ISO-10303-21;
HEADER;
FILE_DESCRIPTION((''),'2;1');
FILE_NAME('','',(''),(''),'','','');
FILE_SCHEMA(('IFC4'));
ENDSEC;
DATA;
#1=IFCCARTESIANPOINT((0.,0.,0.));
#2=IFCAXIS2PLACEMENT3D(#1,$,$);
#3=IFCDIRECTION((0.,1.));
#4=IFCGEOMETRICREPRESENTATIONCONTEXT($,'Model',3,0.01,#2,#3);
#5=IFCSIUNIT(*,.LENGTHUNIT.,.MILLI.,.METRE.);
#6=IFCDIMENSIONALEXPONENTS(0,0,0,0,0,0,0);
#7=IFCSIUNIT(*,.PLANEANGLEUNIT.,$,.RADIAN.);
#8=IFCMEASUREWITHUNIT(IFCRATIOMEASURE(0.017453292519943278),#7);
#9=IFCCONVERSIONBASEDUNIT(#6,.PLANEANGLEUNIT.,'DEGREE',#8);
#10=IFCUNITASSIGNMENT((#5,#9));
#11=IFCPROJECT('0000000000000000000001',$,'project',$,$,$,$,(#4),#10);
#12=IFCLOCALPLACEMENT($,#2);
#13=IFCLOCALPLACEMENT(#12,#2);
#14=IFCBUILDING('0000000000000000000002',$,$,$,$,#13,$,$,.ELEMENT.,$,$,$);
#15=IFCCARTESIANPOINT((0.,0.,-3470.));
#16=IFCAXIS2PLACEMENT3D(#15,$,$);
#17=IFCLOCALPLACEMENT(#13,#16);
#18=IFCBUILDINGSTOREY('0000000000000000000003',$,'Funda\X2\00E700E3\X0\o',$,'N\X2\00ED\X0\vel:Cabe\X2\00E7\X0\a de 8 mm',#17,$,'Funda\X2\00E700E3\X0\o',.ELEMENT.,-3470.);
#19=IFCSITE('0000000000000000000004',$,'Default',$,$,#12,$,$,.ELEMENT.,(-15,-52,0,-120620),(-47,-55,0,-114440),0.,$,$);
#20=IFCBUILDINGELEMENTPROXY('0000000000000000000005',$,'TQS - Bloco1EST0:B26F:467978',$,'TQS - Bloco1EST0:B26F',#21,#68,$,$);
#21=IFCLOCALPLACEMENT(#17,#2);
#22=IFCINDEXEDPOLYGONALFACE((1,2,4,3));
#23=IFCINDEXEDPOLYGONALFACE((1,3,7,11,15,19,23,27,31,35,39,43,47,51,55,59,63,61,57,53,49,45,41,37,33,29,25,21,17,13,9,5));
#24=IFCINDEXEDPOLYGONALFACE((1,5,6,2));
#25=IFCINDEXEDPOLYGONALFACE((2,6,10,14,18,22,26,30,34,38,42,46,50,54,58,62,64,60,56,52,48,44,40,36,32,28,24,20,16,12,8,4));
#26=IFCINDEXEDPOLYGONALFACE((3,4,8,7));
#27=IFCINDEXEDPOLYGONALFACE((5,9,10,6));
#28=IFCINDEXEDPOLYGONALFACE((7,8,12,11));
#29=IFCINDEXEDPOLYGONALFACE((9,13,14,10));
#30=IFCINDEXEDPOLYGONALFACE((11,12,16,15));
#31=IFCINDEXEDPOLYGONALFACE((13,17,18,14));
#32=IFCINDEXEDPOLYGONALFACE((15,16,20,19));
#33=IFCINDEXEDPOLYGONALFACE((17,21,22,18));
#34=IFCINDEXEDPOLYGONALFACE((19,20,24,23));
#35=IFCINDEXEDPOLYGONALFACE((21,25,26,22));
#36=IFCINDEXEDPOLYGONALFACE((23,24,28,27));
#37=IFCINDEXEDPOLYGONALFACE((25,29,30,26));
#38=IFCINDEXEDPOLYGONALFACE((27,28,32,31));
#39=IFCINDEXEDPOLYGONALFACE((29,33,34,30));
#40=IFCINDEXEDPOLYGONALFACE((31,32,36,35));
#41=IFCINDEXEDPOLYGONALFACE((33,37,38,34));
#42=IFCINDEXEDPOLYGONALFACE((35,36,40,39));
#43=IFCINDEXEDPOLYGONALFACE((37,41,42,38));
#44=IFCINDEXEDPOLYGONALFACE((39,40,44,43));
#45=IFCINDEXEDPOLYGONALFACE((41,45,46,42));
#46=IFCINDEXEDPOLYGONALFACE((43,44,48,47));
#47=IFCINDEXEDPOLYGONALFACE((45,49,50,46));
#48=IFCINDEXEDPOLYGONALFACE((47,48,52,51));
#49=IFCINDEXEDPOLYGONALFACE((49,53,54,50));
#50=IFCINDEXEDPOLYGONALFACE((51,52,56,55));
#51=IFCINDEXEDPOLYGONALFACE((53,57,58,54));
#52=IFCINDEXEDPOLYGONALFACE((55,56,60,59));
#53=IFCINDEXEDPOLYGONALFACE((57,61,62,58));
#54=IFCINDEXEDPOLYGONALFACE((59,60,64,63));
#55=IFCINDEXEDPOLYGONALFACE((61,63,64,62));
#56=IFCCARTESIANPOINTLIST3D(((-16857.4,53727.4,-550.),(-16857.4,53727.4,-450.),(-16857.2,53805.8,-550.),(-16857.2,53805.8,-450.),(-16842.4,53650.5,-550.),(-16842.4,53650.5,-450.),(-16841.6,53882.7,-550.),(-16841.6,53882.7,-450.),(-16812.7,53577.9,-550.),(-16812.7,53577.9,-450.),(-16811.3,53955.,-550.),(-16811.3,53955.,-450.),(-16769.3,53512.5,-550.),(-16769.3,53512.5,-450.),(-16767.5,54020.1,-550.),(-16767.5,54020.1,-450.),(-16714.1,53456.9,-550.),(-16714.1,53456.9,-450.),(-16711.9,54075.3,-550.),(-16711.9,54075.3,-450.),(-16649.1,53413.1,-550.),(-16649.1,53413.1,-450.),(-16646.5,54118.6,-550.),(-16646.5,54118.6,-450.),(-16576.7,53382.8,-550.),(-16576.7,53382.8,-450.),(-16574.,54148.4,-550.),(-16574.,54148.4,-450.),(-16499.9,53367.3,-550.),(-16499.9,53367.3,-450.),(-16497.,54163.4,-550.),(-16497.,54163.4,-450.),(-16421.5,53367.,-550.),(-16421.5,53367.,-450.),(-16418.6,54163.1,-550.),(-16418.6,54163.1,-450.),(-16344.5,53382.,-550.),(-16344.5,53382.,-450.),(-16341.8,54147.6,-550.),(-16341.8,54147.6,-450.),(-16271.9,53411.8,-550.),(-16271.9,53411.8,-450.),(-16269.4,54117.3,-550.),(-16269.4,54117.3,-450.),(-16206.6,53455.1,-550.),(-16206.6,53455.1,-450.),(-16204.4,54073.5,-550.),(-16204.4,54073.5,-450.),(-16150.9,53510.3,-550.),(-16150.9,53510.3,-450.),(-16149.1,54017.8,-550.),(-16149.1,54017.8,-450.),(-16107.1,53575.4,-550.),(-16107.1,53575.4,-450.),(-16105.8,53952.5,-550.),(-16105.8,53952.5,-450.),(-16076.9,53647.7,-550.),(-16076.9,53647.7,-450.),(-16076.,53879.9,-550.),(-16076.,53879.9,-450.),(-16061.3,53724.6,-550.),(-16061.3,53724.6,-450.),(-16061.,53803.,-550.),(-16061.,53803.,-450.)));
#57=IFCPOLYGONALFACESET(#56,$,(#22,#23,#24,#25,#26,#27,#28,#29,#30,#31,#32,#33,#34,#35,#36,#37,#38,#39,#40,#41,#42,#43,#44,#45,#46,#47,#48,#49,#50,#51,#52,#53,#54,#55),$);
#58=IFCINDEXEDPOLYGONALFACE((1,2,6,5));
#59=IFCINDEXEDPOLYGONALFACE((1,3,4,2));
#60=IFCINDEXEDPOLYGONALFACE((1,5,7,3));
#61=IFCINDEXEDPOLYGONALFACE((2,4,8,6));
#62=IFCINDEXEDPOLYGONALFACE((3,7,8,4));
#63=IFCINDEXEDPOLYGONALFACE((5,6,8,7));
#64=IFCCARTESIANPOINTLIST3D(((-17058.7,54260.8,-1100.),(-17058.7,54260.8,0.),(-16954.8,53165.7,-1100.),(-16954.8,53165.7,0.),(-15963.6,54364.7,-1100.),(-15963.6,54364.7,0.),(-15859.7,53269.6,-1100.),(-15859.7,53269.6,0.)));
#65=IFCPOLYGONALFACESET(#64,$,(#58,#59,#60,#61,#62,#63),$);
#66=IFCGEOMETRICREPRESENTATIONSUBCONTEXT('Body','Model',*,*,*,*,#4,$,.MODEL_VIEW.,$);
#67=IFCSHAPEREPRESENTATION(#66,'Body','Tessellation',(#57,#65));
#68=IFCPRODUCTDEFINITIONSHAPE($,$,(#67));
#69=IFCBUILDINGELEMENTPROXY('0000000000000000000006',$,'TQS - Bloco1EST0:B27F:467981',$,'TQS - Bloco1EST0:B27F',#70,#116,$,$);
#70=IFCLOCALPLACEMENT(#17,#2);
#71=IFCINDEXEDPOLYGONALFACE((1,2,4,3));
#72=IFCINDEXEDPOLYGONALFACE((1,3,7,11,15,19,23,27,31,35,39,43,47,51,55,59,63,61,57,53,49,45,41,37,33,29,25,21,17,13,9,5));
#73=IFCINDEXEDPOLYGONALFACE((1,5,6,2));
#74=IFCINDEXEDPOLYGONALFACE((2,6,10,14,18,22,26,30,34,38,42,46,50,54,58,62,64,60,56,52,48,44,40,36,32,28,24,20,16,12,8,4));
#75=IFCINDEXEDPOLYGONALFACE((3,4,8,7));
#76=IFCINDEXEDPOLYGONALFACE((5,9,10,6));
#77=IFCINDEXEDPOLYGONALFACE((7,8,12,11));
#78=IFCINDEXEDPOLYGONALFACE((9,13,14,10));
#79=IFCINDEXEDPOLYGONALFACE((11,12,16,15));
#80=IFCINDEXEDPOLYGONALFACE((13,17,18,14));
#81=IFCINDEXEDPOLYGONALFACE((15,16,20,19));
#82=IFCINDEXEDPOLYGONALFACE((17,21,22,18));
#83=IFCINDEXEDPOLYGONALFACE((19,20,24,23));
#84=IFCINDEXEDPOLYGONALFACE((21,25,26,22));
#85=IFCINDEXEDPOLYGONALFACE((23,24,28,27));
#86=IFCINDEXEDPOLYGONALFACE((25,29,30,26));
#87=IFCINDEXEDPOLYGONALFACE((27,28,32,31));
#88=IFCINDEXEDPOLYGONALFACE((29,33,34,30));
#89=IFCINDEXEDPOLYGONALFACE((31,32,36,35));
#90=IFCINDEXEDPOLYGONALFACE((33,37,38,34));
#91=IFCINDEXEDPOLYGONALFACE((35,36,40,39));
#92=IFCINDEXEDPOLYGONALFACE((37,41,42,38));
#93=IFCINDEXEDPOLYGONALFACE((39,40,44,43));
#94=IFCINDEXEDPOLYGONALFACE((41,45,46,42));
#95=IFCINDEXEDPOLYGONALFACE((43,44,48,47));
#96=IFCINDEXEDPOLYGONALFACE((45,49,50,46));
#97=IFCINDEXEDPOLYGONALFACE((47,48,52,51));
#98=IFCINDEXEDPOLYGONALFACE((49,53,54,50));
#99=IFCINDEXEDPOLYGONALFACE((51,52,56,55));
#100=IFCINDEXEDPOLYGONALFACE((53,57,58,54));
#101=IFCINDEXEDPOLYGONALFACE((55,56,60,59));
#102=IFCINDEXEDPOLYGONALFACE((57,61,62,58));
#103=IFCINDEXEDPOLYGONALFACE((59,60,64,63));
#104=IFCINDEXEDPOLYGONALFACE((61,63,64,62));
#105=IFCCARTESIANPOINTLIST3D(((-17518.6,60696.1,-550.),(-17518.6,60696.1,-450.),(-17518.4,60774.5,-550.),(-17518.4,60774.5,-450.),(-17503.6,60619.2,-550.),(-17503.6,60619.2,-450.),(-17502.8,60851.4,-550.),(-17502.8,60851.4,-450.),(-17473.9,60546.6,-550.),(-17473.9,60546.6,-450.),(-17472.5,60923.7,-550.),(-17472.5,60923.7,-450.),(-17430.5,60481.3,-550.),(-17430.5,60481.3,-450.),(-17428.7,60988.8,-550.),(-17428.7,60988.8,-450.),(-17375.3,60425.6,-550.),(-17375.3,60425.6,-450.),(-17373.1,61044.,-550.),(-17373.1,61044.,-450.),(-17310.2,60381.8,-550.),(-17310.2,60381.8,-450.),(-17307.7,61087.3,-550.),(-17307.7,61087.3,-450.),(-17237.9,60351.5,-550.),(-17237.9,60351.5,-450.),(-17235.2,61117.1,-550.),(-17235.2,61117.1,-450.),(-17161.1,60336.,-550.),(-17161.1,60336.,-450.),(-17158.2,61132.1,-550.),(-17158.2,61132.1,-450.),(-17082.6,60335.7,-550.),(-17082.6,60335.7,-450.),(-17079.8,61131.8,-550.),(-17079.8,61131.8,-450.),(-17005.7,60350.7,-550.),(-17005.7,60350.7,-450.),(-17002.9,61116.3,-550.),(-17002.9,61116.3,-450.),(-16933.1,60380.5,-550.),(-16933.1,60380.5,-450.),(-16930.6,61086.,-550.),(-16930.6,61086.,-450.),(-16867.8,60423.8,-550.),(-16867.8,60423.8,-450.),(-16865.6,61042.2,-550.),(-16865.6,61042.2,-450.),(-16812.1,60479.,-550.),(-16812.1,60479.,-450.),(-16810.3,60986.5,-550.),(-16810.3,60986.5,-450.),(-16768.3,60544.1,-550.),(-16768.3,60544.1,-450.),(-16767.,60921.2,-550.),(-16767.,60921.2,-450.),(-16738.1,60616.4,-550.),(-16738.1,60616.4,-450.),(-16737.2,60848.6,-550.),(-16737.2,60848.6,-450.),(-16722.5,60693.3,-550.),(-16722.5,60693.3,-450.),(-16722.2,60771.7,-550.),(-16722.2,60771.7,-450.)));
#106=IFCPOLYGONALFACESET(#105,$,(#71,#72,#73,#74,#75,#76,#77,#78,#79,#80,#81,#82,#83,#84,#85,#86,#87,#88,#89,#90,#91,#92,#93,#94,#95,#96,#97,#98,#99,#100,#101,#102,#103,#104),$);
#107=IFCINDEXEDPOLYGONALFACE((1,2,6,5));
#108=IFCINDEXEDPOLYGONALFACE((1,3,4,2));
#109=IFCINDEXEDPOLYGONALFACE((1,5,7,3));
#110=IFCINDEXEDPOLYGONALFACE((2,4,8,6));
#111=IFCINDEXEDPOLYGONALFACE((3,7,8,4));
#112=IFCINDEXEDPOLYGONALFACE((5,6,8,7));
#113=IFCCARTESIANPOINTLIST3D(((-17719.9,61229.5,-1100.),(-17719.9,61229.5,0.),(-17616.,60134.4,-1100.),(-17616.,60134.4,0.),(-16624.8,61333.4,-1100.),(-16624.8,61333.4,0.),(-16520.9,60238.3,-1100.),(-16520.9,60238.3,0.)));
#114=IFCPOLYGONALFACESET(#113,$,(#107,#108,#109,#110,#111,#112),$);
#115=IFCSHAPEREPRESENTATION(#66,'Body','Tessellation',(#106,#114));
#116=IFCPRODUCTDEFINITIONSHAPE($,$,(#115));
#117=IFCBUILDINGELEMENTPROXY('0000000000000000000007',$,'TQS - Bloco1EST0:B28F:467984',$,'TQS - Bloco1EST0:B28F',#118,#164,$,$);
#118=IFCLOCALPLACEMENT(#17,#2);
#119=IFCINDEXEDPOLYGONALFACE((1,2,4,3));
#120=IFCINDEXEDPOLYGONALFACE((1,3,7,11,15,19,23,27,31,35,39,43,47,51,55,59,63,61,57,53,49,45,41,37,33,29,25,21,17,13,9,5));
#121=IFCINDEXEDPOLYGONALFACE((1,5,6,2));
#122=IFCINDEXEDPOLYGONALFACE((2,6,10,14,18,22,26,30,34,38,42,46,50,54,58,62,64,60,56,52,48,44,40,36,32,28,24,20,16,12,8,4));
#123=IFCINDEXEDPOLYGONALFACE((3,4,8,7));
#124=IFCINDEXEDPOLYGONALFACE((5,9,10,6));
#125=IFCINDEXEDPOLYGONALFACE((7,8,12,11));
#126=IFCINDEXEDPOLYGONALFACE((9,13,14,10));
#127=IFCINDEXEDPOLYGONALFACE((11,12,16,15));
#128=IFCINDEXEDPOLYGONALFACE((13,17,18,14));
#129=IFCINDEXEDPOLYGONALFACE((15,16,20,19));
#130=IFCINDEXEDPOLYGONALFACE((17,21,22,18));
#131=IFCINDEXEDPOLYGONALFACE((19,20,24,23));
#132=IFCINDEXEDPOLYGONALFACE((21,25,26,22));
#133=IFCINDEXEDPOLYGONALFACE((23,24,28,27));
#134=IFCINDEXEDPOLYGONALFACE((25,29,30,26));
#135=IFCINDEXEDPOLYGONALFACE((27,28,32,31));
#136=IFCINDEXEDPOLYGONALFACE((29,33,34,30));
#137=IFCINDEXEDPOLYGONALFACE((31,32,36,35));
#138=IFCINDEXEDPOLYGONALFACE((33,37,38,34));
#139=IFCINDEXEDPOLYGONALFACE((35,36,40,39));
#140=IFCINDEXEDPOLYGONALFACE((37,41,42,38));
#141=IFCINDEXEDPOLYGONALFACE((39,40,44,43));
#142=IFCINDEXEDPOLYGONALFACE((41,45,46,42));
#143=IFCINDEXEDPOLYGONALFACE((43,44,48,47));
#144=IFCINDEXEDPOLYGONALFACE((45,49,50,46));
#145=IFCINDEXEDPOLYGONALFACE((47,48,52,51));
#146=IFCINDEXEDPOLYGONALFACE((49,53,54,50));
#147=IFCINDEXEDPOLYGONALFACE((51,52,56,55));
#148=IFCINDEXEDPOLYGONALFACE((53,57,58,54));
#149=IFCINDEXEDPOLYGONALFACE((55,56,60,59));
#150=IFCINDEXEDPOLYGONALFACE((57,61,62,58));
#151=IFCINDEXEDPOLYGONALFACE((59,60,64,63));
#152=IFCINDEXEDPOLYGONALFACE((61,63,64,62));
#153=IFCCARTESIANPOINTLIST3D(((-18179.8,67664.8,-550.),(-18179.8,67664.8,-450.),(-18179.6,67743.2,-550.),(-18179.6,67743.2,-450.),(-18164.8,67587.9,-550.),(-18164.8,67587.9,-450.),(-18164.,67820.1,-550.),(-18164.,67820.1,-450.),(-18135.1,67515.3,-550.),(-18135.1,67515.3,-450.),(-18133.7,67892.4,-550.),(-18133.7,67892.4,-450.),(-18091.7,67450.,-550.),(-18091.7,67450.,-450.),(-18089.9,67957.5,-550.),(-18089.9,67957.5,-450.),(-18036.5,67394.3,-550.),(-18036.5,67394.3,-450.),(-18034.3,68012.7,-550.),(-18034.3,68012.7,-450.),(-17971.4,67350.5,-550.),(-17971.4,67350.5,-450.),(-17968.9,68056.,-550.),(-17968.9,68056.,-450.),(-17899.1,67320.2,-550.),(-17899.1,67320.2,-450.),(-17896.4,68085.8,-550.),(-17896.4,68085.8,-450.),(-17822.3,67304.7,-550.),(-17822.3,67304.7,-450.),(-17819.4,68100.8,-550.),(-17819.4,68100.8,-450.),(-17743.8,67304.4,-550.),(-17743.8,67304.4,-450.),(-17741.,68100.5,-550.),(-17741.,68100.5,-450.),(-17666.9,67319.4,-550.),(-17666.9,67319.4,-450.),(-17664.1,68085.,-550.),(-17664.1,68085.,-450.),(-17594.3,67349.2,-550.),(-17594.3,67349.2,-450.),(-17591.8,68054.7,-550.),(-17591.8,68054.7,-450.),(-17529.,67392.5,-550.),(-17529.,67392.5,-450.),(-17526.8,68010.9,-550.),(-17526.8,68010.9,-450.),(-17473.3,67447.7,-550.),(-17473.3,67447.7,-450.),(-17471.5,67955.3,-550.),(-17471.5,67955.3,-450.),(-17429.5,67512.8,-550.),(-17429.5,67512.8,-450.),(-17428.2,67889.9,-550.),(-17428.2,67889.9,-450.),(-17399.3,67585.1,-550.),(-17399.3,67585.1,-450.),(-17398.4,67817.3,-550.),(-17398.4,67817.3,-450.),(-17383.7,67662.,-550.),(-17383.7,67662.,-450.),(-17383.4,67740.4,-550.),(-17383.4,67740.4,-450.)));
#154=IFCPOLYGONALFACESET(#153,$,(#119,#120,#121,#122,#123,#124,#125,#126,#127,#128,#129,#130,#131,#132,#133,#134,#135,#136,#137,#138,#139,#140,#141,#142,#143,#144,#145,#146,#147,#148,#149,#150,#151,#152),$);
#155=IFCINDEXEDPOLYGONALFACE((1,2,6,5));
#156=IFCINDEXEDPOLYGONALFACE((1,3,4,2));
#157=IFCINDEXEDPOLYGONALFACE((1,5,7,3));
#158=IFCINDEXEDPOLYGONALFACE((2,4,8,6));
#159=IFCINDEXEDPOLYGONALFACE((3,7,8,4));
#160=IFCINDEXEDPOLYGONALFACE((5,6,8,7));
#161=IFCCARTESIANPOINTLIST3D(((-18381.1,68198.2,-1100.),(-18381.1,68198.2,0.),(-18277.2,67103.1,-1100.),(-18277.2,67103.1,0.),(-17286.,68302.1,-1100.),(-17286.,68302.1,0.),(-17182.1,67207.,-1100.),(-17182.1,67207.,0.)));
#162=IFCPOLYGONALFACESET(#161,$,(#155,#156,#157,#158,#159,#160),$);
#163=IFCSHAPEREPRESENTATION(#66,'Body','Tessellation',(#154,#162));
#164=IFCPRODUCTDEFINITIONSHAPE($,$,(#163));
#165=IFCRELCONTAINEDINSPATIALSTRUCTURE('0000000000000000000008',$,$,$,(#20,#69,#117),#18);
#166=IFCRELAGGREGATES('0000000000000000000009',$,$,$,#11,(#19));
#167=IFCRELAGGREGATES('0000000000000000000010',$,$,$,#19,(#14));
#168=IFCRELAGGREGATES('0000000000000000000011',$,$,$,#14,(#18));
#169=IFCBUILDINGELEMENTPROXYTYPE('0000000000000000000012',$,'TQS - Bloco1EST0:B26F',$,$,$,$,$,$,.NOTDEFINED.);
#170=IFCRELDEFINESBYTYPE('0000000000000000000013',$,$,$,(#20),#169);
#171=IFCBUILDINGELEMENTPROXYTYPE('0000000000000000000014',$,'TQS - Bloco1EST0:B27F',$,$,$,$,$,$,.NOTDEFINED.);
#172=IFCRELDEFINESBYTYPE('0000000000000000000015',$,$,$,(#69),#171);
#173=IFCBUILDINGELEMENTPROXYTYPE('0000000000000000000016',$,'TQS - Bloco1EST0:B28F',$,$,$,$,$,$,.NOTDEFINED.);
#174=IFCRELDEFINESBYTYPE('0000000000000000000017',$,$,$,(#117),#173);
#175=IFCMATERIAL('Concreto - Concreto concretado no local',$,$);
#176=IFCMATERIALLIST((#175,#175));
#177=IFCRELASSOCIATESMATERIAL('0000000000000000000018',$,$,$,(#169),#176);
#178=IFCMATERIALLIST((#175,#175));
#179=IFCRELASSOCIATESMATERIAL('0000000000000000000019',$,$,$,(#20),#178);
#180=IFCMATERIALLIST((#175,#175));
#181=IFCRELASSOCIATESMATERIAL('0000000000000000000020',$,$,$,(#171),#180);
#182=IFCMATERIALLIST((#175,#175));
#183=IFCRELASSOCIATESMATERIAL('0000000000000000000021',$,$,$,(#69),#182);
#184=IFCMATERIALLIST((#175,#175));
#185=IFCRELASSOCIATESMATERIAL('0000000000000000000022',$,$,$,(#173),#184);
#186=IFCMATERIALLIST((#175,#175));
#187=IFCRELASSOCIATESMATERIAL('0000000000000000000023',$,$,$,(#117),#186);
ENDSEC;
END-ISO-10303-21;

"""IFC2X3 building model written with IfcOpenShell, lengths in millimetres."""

from ifc_helpers import new_model, entity, si_unit, converted_unit, direction, frame, frame_2d, origin, origin_2d_with_axis, place, context, subcontext, project, spatial, rectangle, circle, extrude, source, transform, mapped, material, material_list, type_object, type_shapes, element, save


model = new_model("IFC2X3")

# Units and contexts
model_context = context("Model", 3, precision=0.01, world=origin(), true_north=direction((0.0, 1.0)))
body_context = subcontext(model_context, "Body", "Model", "MODEL_VIEW")
ifc_project = project(units=[si_unit("LENGTHUNIT", "METRE", prefix="MILLI"), converted_unit("PLANEANGLEUNIT", "DEGREE", entity("IfcRatioMeasure", 0.017453292519943278), si_unit("PLANEANGLEUNIT", "RADIAN"), dimensions=[0, 0, 0, 0, 0, 0, 0])], contexts=[model_context])

# Site, building, storey
site_placement = place(None, origin())
site = spatial("IfcSite", under=ifc_project, at=site_placement, Name="Default", CompositionType="ELEMENT", RefLatitude=(-15, -52, 0, -120620), RefLongitude=(-47, -55, 0, -114440), RefElevation=0.0)
building_placement = place(site_placement, origin())
building = spatial("IfcBuilding", under=site, at=building_placement, CompositionType="ELEMENT")
storey_placement = place(building_placement, frame((0.0, 0.0, -3470.0)))
storey = spatial("IfcBuildingStorey", under=building, at=storey_placement, Name="Fundação", ObjectType="Nível:Cabeça de 8 mm", LongName="Fundação", CompositionType="ELEMENT", Elevation=-3470.0)

# Building element proxies
ifc_material_1 = material(Name="Concreto - Concreto concretado no local")
ifc_material_list_1 = material_list([ifc_material_1, ifc_material_1])
ifc_material_list_2 = material_list([ifc_material_1, ifc_material_1])
building_element_proxy_type_1 = type_object("IfcBuildingElementProxyType", Name="TQS - Bloco1EST0:B26F", PredefinedType="NOTDEFINED", material=ifc_material_list_2)
shared_shape_1 = source(origin(), body_context, "Body", "SweptSolid", [
    extrude(circle(Radius=400.0, at=frame_2d((0.0, 0.0), x_axis=(1.0, 0.0))), frame((0.0, 0.0, -550.0)), (0.0, 0.0, 1.0), 100.0),
    extrude(rectangle(XDim=1100.0, YDim=1100.0, at=origin_2d_with_axis()), frame((0.0, 0.0, -1100.0), z_axis=(0.0, 0.0, 1.0), x_axis=(-1.0, 0.0, 0.0)), (0.0, 0.0, 1.0), 1100.0),
])
type_shapes(building_element_proxy_type_1, [shared_shape_1])
proxy_1_placement = place(storey_placement, frame((-16459.2, 53765.2, 0.0), z_axis=(0.0, 0.0, 1.0), x_axis=(-0.094456, 0.995529, 0.0)))
element("IfcBuildingElementProxy", 1, at=proxy_1_placement, inside=storey, type_object=building_element_proxy_type_1, material=ifc_material_list_1, Name="TQS - Bloco1EST0:B26F:467978", ObjectType="TQS - Bloco1EST0:B26F", context=body_context, shape_type="MappedRepresentation", body=[
    mapped(shared_shape_1, transform((0.0, 0.0, 0.0), scale=1.0)),
])
ifc_material_list_3 = material_list([ifc_material_1, ifc_material_1])
ifc_material_list_4 = material_list([ifc_material_1, ifc_material_1])
building_element_proxy_type_2 = type_object("IfcBuildingElementProxyType", Name="TQS - Bloco1EST0:B27F", PredefinedType="NOTDEFINED", material=ifc_material_list_4)
shared_shape_2 = source(origin(), body_context, "Body", "SweptSolid", [
    extrude(circle(Radius=400.0, at=frame_2d((0.0, 0.0), x_axis=(1.0, 0.0))), frame((0.0, 0.0, -550.0)), (0.0, 0.0, 1.0), 100.0),
    extrude(rectangle(XDim=1100.0, YDim=1100.0, at=origin_2d_with_axis()), frame((0.0, 0.0, -1100.0), z_axis=(0.0, 0.0, 1.0), x_axis=(-1.0, 0.0, 0.0)), (0.0, 0.0, 1.0), 1100.0),
])
type_shapes(building_element_proxy_type_2, [shared_shape_2])
proxy_2_placement = place(storey_placement, frame((-17120.4, 60733.9, 0.0), z_axis=(0.0, 0.0, 1.0), x_axis=(-0.094456, 0.995529, 0.0)))
element("IfcBuildingElementProxy", 2, at=proxy_2_placement, inside=storey, type_object=building_element_proxy_type_2, material=ifc_material_list_3, Name="TQS - Bloco1EST0:B27F:467981", ObjectType="TQS - Bloco1EST0:B27F", context=body_context, shape_type="MappedRepresentation", body=[
    mapped(shared_shape_2, transform((0.0, 0.0, 0.0), scale=1.0)),
])
ifc_material_list_5 = material_list([ifc_material_1, ifc_material_1])
ifc_material_list_6 = material_list([ifc_material_1, ifc_material_1])
building_element_proxy_type_3 = type_object("IfcBuildingElementProxyType", Name="TQS - Bloco1EST0:B28F", PredefinedType="NOTDEFINED", material=ifc_material_list_6)
shared_shape_3 = source(origin(), body_context, "Body", "SweptSolid", [
    extrude(circle(Radius=400.0, at=frame_2d((0.0, 0.0), x_axis=(1.0, 0.0))), frame((0.0, 0.0, -550.0)), (0.0, 0.0, 1.0), 100.0),
    extrude(rectangle(XDim=1100.0, YDim=1100.0, at=origin_2d_with_axis()), frame((0.0, 0.0, -1100.0), z_axis=(0.0, 0.0, 1.0), x_axis=(-1.0, 0.0, 0.0)), (0.0, 0.0, 1.0), 1100.0),
])
type_shapes(building_element_proxy_type_3, [shared_shape_3])
proxy_3_placement = place(storey_placement, frame((-17781.6, 67702.6, 0.0), z_axis=(0.0, 0.0, 1.0), x_axis=(-0.094456, 0.995529, 0.0)))
element("IfcBuildingElementProxy", 3, at=proxy_3_placement, inside=storey, type_object=building_element_proxy_type_3, material=ifc_material_list_5, Name="TQS - Bloco1EST0:B28F:467984", ObjectType="TQS - Bloco1EST0:B28F", context=body_context, shape_type="MappedRepresentation", body=[
    mapped(shared_shape_3, transform((0.0, 0.0, 0.0), scale=1.0)),
])

save(model, "model.ifc")
